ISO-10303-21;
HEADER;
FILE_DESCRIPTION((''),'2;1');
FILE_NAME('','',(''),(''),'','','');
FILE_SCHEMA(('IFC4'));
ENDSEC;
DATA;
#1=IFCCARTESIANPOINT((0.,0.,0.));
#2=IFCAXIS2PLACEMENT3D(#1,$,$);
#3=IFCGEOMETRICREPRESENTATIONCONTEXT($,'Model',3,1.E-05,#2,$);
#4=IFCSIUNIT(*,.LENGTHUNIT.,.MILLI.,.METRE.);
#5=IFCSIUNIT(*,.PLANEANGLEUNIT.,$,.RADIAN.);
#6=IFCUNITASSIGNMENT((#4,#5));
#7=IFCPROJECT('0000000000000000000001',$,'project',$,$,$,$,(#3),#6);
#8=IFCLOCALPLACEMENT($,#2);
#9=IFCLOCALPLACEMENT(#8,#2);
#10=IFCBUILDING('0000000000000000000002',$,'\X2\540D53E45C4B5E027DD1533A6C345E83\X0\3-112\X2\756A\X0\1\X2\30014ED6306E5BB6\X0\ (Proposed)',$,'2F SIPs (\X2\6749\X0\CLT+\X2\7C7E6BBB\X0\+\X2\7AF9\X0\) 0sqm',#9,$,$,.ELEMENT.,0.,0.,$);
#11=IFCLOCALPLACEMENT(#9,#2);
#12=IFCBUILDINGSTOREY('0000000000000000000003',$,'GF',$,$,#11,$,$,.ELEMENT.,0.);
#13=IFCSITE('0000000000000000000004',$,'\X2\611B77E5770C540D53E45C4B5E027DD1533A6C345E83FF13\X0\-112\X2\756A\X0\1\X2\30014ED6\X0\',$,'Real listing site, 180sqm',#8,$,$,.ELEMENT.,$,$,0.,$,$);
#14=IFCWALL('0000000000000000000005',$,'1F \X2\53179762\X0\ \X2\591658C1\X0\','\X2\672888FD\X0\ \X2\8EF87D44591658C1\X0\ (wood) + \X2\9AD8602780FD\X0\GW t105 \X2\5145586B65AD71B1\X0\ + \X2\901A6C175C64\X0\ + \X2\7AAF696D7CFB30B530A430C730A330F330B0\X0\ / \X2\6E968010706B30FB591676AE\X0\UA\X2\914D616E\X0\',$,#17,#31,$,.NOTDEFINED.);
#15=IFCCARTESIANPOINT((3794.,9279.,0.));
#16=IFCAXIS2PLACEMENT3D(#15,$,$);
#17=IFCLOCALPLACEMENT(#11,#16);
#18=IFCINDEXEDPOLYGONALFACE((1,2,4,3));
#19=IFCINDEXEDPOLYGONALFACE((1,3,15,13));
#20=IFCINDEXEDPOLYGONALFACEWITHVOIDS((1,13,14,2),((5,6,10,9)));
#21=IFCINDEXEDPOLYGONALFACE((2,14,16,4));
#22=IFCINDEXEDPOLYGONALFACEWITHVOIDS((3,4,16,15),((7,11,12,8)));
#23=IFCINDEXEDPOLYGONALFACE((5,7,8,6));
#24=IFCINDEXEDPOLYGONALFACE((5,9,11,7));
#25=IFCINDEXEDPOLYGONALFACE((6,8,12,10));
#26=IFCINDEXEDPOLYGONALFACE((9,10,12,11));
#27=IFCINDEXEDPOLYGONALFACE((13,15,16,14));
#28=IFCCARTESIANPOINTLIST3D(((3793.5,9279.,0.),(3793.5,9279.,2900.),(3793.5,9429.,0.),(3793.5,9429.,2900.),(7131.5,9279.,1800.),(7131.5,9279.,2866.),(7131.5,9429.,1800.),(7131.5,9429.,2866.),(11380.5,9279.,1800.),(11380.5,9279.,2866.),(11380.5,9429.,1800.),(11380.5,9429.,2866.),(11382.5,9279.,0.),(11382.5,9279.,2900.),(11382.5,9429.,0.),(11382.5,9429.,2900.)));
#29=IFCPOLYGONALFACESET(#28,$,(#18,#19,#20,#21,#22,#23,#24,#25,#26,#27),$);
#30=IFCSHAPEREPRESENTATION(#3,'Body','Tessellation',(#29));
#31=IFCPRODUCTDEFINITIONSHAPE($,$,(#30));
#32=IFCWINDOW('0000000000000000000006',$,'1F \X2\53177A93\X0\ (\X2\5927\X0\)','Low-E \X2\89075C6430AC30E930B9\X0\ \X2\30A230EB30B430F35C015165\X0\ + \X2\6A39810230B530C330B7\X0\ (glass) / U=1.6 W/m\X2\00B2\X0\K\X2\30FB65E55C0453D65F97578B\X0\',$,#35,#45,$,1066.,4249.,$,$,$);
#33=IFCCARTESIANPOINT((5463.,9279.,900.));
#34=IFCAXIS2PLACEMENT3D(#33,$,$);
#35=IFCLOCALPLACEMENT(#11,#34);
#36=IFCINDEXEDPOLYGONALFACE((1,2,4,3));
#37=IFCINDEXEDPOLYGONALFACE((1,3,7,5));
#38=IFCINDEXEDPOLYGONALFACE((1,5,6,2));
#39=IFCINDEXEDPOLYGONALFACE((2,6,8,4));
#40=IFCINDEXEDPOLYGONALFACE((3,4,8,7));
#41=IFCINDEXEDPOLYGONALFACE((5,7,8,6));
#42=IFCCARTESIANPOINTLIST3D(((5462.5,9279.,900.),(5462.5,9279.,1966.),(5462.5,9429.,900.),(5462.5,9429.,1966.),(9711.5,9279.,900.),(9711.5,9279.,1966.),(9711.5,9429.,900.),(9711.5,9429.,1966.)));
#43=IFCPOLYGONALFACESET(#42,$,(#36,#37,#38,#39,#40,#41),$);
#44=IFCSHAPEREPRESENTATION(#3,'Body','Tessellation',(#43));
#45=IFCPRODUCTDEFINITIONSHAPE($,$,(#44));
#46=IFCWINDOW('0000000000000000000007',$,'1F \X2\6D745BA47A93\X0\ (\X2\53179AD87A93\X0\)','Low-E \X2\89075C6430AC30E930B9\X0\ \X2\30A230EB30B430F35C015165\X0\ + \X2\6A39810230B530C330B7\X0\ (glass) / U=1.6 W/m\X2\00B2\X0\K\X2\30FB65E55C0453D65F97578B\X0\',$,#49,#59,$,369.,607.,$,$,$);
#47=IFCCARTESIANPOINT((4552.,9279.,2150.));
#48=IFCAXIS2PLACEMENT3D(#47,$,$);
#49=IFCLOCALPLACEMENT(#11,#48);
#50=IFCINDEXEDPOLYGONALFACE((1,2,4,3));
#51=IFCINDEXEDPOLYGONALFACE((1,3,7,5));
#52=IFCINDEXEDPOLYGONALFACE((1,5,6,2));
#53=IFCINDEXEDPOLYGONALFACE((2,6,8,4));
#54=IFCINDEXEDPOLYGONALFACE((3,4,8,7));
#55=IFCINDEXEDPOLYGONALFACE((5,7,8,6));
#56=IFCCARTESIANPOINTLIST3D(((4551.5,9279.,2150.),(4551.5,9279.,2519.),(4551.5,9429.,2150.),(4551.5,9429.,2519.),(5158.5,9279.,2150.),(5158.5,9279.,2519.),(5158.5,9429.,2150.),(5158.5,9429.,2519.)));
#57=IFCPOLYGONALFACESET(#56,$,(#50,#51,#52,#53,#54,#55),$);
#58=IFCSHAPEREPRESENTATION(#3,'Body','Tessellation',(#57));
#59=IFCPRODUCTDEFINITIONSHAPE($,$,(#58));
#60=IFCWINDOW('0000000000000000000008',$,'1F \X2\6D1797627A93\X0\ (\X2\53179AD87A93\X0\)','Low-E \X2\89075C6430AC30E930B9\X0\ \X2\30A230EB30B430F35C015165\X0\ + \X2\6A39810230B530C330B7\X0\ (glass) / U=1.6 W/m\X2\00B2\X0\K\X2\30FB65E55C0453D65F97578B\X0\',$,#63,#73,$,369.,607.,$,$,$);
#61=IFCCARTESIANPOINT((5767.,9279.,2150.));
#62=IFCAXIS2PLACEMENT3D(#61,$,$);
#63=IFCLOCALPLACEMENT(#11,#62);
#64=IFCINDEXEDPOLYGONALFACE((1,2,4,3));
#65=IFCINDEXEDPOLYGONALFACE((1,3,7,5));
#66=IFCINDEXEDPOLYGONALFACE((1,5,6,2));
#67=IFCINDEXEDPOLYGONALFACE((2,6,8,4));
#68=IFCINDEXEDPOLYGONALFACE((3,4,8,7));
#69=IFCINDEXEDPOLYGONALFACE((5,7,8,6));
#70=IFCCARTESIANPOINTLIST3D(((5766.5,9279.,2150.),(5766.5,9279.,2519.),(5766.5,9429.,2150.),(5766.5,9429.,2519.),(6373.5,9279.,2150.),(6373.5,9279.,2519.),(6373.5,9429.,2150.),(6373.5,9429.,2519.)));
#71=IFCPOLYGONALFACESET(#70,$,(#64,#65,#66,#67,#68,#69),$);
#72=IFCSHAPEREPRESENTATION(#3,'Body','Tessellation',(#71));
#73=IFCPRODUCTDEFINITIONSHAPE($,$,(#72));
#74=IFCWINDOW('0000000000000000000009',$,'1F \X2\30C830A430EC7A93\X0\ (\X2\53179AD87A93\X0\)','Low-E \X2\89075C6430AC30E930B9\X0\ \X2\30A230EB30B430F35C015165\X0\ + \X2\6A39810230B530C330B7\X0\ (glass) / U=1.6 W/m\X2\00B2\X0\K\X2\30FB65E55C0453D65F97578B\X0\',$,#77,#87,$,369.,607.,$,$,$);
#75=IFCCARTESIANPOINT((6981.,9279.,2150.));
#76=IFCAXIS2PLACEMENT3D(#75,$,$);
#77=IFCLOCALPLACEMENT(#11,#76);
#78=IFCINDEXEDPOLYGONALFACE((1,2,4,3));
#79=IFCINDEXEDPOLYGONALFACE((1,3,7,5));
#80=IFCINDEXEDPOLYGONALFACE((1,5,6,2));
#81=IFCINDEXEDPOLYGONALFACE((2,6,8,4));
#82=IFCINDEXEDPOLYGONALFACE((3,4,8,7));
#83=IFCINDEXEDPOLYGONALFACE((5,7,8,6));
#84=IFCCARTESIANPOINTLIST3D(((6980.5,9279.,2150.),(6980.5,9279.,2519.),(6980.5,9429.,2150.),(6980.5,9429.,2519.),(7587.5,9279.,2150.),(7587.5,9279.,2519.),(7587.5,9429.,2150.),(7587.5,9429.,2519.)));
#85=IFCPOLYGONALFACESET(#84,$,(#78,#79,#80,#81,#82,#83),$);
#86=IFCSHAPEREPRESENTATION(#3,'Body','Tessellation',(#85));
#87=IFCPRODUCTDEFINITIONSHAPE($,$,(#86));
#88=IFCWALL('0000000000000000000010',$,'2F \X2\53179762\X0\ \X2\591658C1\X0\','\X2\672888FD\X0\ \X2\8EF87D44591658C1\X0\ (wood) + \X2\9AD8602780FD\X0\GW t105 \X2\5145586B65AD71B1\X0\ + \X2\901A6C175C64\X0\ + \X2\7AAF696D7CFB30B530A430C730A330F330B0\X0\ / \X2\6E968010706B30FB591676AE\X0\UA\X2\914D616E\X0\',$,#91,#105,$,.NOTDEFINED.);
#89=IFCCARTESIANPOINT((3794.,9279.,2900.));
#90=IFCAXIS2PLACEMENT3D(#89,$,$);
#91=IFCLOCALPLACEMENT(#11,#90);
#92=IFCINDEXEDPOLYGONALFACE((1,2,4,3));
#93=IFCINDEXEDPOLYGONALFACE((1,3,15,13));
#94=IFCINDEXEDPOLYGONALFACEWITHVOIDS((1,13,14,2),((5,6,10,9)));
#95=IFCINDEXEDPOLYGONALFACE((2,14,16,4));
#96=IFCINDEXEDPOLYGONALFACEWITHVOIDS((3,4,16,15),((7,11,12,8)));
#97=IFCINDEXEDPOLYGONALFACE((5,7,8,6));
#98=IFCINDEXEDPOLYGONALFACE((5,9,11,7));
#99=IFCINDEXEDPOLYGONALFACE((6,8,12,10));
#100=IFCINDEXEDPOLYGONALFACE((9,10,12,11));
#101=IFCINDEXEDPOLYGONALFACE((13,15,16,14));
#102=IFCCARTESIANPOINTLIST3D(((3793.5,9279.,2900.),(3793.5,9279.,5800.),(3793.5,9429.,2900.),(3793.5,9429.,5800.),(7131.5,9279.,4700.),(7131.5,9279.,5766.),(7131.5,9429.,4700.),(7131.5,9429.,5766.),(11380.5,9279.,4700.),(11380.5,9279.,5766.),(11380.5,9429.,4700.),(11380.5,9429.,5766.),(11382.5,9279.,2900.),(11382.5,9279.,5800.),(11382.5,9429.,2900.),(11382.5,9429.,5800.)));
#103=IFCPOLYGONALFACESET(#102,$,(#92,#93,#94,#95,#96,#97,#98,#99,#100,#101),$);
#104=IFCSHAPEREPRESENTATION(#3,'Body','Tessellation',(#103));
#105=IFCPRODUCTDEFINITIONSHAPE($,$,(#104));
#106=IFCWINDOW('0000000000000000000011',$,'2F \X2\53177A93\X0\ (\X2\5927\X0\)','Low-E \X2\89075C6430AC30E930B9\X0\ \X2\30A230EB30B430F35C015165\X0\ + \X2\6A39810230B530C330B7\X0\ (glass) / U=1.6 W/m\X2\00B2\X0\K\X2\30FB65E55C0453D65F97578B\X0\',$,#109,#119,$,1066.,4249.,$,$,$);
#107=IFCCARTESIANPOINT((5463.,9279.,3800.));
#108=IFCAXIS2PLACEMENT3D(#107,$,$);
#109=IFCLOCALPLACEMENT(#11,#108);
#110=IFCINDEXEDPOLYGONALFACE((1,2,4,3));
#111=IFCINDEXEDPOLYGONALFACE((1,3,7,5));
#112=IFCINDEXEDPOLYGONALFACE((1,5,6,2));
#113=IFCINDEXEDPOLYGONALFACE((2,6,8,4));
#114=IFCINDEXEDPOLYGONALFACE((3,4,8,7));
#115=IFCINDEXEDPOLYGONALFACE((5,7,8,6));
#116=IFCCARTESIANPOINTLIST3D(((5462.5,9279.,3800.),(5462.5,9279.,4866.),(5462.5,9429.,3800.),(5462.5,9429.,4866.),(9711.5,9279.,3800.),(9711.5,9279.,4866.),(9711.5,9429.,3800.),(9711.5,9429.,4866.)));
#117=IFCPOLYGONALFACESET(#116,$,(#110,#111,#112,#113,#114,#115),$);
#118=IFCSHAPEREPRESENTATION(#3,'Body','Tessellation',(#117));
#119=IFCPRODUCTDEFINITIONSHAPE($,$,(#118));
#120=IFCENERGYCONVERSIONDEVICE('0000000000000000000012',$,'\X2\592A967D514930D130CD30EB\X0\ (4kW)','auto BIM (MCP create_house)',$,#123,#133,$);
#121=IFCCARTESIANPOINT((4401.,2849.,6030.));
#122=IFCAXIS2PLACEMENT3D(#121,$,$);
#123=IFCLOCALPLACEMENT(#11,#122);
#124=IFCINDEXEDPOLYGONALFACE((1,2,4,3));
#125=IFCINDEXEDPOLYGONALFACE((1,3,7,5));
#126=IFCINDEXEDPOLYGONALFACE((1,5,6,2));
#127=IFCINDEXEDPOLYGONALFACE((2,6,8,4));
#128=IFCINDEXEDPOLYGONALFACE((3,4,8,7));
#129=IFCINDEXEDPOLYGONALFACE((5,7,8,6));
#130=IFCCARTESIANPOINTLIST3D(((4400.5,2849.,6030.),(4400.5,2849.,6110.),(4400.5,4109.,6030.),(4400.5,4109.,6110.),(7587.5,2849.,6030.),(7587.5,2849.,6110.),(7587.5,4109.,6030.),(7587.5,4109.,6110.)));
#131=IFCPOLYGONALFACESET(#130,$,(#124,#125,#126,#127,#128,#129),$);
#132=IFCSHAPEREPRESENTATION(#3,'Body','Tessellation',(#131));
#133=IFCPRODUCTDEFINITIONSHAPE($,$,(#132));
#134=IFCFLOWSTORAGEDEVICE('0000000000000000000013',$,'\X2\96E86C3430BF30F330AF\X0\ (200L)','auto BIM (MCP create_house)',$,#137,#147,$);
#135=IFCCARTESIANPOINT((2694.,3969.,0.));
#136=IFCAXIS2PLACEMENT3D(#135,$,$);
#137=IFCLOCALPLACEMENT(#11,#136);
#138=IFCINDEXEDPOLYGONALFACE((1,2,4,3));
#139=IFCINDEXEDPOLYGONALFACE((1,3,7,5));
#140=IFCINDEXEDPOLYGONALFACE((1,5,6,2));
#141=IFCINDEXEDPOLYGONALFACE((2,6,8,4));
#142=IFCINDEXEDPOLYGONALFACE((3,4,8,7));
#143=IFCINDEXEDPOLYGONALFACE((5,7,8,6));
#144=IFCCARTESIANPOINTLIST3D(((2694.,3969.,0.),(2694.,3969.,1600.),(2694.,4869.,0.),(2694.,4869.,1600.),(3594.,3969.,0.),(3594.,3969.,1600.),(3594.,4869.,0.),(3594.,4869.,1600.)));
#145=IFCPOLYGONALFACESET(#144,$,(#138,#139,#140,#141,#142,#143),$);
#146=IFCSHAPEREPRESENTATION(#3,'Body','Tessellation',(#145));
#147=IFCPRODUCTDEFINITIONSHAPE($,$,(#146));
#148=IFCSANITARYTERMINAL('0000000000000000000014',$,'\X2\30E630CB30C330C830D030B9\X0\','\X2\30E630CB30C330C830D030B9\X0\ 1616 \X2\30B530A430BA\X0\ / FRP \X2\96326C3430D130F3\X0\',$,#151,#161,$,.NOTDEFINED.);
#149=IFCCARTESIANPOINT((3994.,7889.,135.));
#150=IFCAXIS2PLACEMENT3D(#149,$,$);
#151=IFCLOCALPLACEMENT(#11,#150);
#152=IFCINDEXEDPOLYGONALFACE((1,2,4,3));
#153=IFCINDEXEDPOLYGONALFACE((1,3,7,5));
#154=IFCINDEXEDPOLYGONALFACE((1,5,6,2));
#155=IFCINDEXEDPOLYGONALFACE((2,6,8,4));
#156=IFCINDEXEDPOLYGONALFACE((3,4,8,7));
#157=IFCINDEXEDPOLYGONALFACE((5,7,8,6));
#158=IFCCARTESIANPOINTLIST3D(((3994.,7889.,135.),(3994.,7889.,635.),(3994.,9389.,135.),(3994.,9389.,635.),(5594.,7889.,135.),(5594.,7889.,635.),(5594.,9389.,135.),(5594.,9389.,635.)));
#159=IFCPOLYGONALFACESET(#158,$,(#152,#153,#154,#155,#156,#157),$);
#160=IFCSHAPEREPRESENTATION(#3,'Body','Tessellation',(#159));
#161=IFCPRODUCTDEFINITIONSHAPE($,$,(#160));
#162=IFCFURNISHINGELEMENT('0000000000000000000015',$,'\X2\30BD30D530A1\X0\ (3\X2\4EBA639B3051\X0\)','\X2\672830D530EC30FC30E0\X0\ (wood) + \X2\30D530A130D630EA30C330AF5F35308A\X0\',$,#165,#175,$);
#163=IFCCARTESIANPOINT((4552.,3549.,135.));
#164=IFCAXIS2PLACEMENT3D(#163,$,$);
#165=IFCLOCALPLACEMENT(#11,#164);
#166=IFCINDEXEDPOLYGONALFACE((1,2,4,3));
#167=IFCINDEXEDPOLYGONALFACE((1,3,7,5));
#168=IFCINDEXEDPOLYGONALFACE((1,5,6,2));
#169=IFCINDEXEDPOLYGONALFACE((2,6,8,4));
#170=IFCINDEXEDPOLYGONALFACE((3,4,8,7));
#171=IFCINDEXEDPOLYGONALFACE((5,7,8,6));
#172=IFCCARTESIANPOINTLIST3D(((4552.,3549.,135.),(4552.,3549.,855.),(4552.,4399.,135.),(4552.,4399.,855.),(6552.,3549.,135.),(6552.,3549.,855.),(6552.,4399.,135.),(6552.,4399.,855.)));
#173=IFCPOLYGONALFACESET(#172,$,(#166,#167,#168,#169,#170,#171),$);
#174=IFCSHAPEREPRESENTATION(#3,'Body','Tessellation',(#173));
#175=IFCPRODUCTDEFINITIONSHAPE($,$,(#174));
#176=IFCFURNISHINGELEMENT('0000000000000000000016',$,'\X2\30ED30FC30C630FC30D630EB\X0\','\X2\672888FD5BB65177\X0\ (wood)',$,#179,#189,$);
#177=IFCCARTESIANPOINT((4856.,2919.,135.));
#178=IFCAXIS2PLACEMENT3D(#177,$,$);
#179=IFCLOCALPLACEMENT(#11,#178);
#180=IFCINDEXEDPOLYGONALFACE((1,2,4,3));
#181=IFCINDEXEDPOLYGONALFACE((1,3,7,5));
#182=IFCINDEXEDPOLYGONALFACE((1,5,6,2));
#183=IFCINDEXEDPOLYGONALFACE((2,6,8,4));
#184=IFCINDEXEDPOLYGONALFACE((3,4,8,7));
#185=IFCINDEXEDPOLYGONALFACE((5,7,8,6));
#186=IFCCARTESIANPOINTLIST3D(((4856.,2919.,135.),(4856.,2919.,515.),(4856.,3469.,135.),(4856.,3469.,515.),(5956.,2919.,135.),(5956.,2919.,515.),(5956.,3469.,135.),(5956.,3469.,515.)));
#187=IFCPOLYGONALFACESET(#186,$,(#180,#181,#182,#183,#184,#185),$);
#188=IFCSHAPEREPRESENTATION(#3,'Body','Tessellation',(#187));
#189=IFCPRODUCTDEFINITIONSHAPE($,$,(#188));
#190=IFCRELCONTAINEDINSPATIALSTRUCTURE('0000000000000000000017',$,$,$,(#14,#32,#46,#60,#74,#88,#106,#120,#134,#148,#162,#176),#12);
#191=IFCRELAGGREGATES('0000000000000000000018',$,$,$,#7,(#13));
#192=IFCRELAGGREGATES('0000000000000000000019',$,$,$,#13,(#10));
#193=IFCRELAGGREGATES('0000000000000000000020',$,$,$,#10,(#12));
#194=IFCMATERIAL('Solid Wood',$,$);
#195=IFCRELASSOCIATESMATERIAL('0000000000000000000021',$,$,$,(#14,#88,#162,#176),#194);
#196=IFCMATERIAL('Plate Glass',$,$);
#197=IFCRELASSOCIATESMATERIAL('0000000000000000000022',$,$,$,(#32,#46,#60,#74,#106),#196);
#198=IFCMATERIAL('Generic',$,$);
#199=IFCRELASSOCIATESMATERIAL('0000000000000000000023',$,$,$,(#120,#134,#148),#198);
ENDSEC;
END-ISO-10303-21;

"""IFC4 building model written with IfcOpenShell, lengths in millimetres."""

from ifc_helpers import new_model, si_unit, frame, frame_2d, origin, place, context, project, spatial, rectangle, extrude, material, element, fill, save


model = new_model("IFC4")

# Units and contexts
model_context = context("Model", 3, precision=1e-05, world=origin())
ifc_project = project(units=[si_unit("LENGTHUNIT", "METRE", prefix="MILLI"), si_unit("PLANEANGLEUNIT", "RADIAN")], contexts=[model_context])

# Site, building, storey
site_placement = place(None, origin())
site = spatial("IfcSite", under=ifc_project, at=site_placement, Name="愛知県名古屋市緑区水広３-112番1、他", ObjectType="Real listing site, 180sqm", CompositionType="ELEMENT", RefElevation=0.0)
building_placement = place(site_placement, origin())
building = spatial("IfcBuilding", under=site, at=building_placement, Name="名古屋市緑区水広3-112番1、他の家 (Proposed)", ObjectType="2F SIPs (杉CLT+籾殻+竹) 0sqm", CompositionType="ELEMENT", ElevationOfRefHeight=0.0, ElevationOfTerrain=0.0)
storey_placement = place(building_placement, origin())
storey = spatial("IfcBuildingStorey", under=building, at=storey_placement, Name="GF", CompositionType="ELEMENT", Elevation=0.0)

# Wall, openings, windows
ifc_material_1 = material(Name="Solid Wood")
wall_1_placement = place(storey_placement, frame((3794.0, 9279.0, 0.0)))
wall_1 = element("IfcWall", 1, at=wall_1_placement, inside=storey, material=ifc_material_1, Name="1F 北面 外壁", Description="木製 軸組外壁 (wood) + 高性能GW t105 充填断熱 + 通気層 + 窯業系サイディング / 準耐火・外皮UA配慮", PredefinedType="NOTDEFINED", context=model_context, shape_type="SweptSolid", body=[
    extrude(rectangle(XDim=7589.0, YDim=150.0, at=frame_2d((3794.0, 75.0))), frame((3794.0, 9279.0, 0.0)), (0.0, 0.0, 1.0), 2900.0),
])
opening_1_placement = place(storey_placement, frame((5463.0, 9279.0, 900.0)))
opening_1 = element("IfcOpeningElement", 2, at=opening_1_placement, cuts=wall_1, PredefinedType="NOTDEFINED", context=model_context, shape_type="SweptSolid", body=[
    extrude(rectangle(XDim=4249.0, YDim=150.0, at=frame_2d((2124.0, 75.0))), frame((5463.0, 9279.0, 900.0)), (0.0, 0.0, 1.0), 1066.0),
])
opening_2_placement = place(storey_placement, frame((4552.0, 9279.0, 2150.0)))
opening_2 = element("IfcOpeningElement", 3, at=opening_2_placement, cuts=wall_1, PredefinedType="NOTDEFINED", context=model_context, shape_type="SweptSolid", body=[
    extrude(rectangle(XDim=607.0, YDim=150.0, at=frame_2d((303.0, 75.0))), frame((4552.0, 9279.0, 2150.0)), (0.0, 0.0, 1.0), 369.0),
])
opening_3_placement = place(storey_placement, frame((5767.0, 9279.0, 2150.0)))
opening_3 = element("IfcOpeningElement", 4, at=opening_3_placement, cuts=wall_1, PredefinedType="NOTDEFINED", context=model_context, shape_type="SweptSolid", body=[
    extrude(rectangle(XDim=607.0, YDim=150.0, at=frame_2d((303.0, 75.0))), frame((5767.0, 9279.0, 2150.0)), (0.0, 0.0, 1.0), 369.0),
])
opening_4_placement = place(storey_placement, frame((6981.0, 9279.0, 2150.0)))
opening_4 = element("IfcOpeningElement", 5, at=opening_4_placement, cuts=wall_1, PredefinedType="NOTDEFINED", context=model_context, shape_type="SweptSolid", body=[
    extrude(rectangle(XDim=607.0, YDim=150.0, at=frame_2d((303.0, 75.0))), frame((6981.0, 9279.0, 2150.0)), (0.0, 0.0, 1.0), 369.0),
])
ifc_material_2 = material(Name="Plate Glass")
window_1_placement = place(storey_placement, frame((5463.0, 9279.0, 900.0)))
window_1 = element("IfcWindow", 6, at=window_1_placement, inside=storey, material=ifc_material_2, Name="1F 北窓 (大)", Description="Low-E 複層ガラス アルゴン封入 + 樹脂サッシ (glass) / U=1.6 W/m²K・日射取得型", OverallHeight=1066.0, OverallWidth=4249.0, context=model_context, shape_type="SweptSolid", body=[
    extrude(rectangle(XDim=4249.0, YDim=150.0, at=frame_2d((2124.0, 75.0))), frame((5463.0, 9279.0, 900.0)), (0.0, 0.0, 1.0), 1066.0),
])
fill(opening_1, window_1)
window_2_placement = place(storey_placement, frame((4552.0, 9279.0, 2150.0)))
window_2 = element("IfcWindow", 7, at=window_2_placement, inside=storey, material=ifc_material_2, Name="1F 浴室窓 (北高窓)", Description="Low-E 複層ガラス アルゴン封入 + 樹脂サッシ (glass) / U=1.6 W/m²K・日射取得型", OverallHeight=369.0, OverallWidth=607.0, context=model_context, shape_type="SweptSolid", body=[
    extrude(rectangle(XDim=607.0, YDim=150.0, at=frame_2d((303.0, 75.0))), frame((4552.0, 9279.0, 2150.0)), (0.0, 0.0, 1.0), 369.0),
])
fill(opening_2, window_2)
window_3_placement = place(storey_placement, frame((5767.0, 9279.0, 2150.0)))
window_3 = element("IfcWindow", 8, at=window_3_placement, inside=storey, material=ifc_material_2, Name="1F 洗面窓 (北高窓)", Description="Low-E 複層ガラス アルゴン封入 + 樹脂サッシ (glass) / U=1.6 W/m²K・日射取得型", OverallHeight=369.0, OverallWidth=607.0, context=model_context, shape_type="SweptSolid", body=[
    extrude(rectangle(XDim=607.0, YDim=150.0, at=frame_2d((303.0, 75.0))), frame((5767.0, 9279.0, 2150.0)), (0.0, 0.0, 1.0), 369.0),
])
fill(opening_3, window_3)
window_4_placement = place(storey_placement, frame((6981.0, 9279.0, 2150.0)))
window_4 = element("IfcWindow", 9, at=window_4_placement, inside=storey, material=ifc_material_2, Name="1F トイレ窓 (北高窓)", Description="Low-E 複層ガラス アルゴン封入 + 樹脂サッシ (glass) / U=1.6 W/m²K・日射取得型", OverallHeight=369.0, OverallWidth=607.0, context=model_context, shape_type="SweptSolid", body=[
    extrude(rectangle(XDim=607.0, YDim=150.0, at=frame_2d((303.0, 75.0))), frame((6981.0, 9279.0, 2150.0)), (0.0, 0.0, 1.0), 369.0),
])
fill(opening_4, window_4)

# Wall, opening, window
wall_2_placement = place(storey_placement, frame((3794.0, 9279.0, 2900.0)))
wall_2 = element("IfcWall", 10, at=wall_2_placement, inside=storey, material=ifc_material_1, Name="2F 北面 外壁", Description="木製 軸組外壁 (wood) + 高性能GW t105 充填断熱 + 通気層 + 窯業系サイディング / 準耐火・外皮UA配慮", PredefinedType="NOTDEFINED", context=model_context, shape_type="SweptSolid", body=[
    extrude(rectangle(XDim=7589.0, YDim=150.0, at=frame_2d((3794.0, 75.0))), frame((3794.0, 9279.0, 2900.0)), (0.0, 0.0, 1.0), 2900.0),
])
opening_5_placement = place(storey_placement, frame((5463.0, 9279.0, 3800.0)))
opening_5 = element("IfcOpeningElement", 11, at=opening_5_placement, cuts=wall_2, PredefinedType="NOTDEFINED", context=model_context, shape_type="SweptSolid", body=[
    extrude(rectangle(XDim=4249.0, YDim=150.0, at=frame_2d((2124.0, 75.0))), frame((5463.0, 9279.0, 3800.0)), (0.0, 0.0, 1.0), 1066.0),
])
window_5_placement = place(storey_placement, frame((5463.0, 9279.0, 3800.0)))
window_5 = element("IfcWindow", 12, at=window_5_placement, inside=storey, material=ifc_material_2, Name="2F 北窓 (大)", Description="Low-E 複層ガラス アルゴン封入 + 樹脂サッシ (glass) / U=1.6 W/m²K・日射取得型", OverallHeight=1066.0, OverallWidth=4249.0, context=model_context, shape_type="SweptSolid", body=[
    extrude(rectangle(XDim=4249.0, YDim=150.0, at=frame_2d((2124.0, 75.0))), frame((5463.0, 9279.0, 3800.0)), (0.0, 0.0, 1.0), 1066.0),
])
fill(opening_5, window_5)

# Energy conversion device
ifc_material_3 = material(Name="Generic")
energy_conversion_device_placement = place(storey_placement, frame((4401.0, 2849.0, 6030.0)))
element("IfcEnergyConversionDevice", 13, at=energy_conversion_device_placement, inside=storey, material=ifc_material_3, Name="太陽光パネル (4kW)", Description="auto BIM (MCP create_house)", context=model_context, shape_type="SweptSolid", body=[
    extrude(rectangle(XDim=3187.0, YDim=1260.0, at=frame_2d((1593.0, 630.0))), frame((4401.0, 2849.0, 6030.0)), (0.0, 0.0, 1.0), 80.0),
])

# Flow storage device
flow_storage_device_placement = place(storey_placement, frame((2694.0, 3969.0, 0.0)))
element("IfcFlowStorageDevice", 14, at=flow_storage_device_placement, inside=storey, material=ifc_material_3, Name="雨水タンク (200L)", Description="auto BIM (MCP create_house)", context=model_context, shape_type="SweptSolid", body=[
    extrude(rectangle(XDim=900.0, YDim=900.0, at=frame_2d((450.0, 450.0))), frame((2694.0, 3969.0, 0.0)), (0.0, 0.0, 1.0), 1600.0),
])

# Sanitary terminal
sanitary_terminal_placement = place(storey_placement, frame((3994.0, 7889.0, 135.0)))
element("IfcSanitaryTerminal", 15, at=sanitary_terminal_placement, inside=storey, material=ifc_material_3, Name="ユニットバス", Description="ユニットバス 1616 サイズ / FRP 防水パン", PredefinedType="NOTDEFINED", context=model_context, shape_type="SweptSolid", body=[
    extrude(rectangle(XDim=1600.0, YDim=1500.0, at=frame_2d((800.0, 750.0))), frame((3994.0, 7889.0, 135.0)), (0.0, 0.0, 1.0), 500.0),
])

# Furnishing elements
furnishing_1_placement = place(storey_placement, frame((4552.0, 3549.0, 135.0)))
element("IfcFurnishingElement", 16, at=furnishing_1_placement, inside=storey, material=ifc_material_1, Name="ソファ (3人掛け)", Description="木フレーム (wood) + ファブリック張り", context=model_context, shape_type="SweptSolid", body=[
    extrude(rectangle(XDim=2000.0, YDim=850.0, at=frame_2d((1000.0, 425.0))), frame((4552.0, 3549.0, 135.0)), (0.0, 0.0, 1.0), 720.0),
])
furnishing_2_placement = place(storey_placement, frame((4856.0, 2919.0, 135.0)))
element("IfcFurnishingElement", 17, at=furnishing_2_placement, inside=storey, material=ifc_material_1, Name="ローテーブル", Description="木製家具 (wood)", context=model_context, shape_type="SweptSolid", body=[
    extrude(rectangle(XDim=1100.0, YDim=550.0, at=frame_2d((550.0, 275.0))), frame((4856.0, 2919.0, 135.0)), (0.0, 0.0, 1.0), 380.0),
])

save(model, "model.ifc")
